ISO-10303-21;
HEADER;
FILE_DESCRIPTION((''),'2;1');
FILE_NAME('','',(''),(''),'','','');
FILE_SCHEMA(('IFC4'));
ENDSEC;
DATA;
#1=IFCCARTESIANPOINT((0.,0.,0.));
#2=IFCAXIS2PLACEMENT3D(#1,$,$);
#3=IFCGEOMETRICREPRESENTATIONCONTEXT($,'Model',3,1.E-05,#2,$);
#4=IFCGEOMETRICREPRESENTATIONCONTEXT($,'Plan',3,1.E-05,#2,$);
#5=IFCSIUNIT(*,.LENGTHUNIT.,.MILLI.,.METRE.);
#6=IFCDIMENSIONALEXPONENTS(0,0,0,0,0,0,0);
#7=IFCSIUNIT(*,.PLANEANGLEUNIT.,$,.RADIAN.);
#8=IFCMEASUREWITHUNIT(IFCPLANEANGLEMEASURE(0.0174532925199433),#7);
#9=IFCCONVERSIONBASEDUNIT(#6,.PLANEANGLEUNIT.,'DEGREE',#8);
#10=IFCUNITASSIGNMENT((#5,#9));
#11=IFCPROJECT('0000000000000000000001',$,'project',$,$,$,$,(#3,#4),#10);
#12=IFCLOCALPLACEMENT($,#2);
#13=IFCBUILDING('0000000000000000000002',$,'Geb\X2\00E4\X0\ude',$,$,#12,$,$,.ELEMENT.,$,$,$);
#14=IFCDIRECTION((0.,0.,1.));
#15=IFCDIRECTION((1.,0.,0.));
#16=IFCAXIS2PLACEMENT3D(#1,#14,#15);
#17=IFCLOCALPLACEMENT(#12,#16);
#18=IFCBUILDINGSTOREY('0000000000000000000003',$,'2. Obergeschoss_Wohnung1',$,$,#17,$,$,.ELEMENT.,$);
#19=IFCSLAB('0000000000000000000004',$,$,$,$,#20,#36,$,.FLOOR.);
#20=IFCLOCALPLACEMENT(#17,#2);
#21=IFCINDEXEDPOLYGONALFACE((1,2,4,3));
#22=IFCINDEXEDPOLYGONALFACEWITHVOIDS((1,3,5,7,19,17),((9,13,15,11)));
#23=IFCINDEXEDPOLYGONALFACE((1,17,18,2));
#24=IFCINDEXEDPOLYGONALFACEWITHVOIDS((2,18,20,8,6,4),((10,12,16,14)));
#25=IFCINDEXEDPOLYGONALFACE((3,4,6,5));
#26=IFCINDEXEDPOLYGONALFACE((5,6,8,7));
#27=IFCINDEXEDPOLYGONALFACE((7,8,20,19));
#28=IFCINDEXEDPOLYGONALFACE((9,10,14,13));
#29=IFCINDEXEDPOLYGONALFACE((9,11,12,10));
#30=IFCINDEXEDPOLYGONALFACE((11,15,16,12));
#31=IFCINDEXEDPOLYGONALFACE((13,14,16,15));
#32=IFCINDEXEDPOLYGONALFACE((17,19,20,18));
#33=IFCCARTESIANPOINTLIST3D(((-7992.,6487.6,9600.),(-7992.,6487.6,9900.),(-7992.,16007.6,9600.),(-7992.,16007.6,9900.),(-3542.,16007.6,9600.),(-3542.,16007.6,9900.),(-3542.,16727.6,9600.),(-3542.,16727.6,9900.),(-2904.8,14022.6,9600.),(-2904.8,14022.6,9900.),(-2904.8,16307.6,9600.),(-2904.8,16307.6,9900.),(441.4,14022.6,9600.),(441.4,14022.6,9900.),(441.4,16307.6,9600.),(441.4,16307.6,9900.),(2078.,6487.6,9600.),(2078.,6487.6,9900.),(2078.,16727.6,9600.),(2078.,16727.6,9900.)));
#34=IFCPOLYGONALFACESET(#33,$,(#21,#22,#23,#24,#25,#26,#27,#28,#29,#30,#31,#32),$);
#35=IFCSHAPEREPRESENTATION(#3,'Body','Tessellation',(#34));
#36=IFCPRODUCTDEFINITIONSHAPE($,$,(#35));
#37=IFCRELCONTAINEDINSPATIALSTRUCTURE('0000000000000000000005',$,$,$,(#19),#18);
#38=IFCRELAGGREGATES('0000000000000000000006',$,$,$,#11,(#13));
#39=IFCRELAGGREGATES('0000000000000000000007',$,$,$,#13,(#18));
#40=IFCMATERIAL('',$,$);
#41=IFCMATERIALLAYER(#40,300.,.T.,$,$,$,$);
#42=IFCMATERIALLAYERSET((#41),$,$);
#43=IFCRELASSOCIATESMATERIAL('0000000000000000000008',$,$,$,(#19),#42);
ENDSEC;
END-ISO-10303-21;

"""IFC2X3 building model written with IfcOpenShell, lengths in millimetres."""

from ifc_helpers import new_model, entity, si_unit, converted_unit, frame, frame_2d, origin, origin_with_axes, place, context, project, spatial, polyline, rectangle, outline, extrude, material, layer, layer_set, layer_usage, element, save


model = new_model("IFC2X3")

# Units and contexts
model_context = context("Model", 3, precision=1e-05, world=origin())
plan_context = context("Plan", 3, precision=1e-05, world=origin())
ifc_project = project(units=[si_unit("LENGTHUNIT", "METRE", prefix="MILLI"), converted_unit("PLANEANGLEUNIT", "DEGREE", entity("IfcPlaneAngleMeasure", 0.0174532925199433), si_unit("PLANEANGLEUNIT", "RADIAN"), dimensions=[0, 0, 0, 0, 0, 0, 0])], contexts=[model_context, plan_context])

# Building, storey
building_placement = place(None, origin())
building = spatial("IfcBuilding", under=ifc_project, at=building_placement, Name="Gebäude", CompositionType="ELEMENT")
storey_placement = place(building_placement, origin_with_axes())
storey = spatial("IfcBuildingStorey", under=building, at=storey_placement, Name="2. Obergeschoss_Wohnung1", CompositionType="ELEMENT")

# Slab, opening
ifc_material = material(Name="")
ifc_layer = layer(ifc_material, 300.0, ventilated=True)
ifc_layer_set = layer_set([ifc_layer])
ifc_layer_usage = layer_usage(ifc_layer_set, "AXIS3", "POSITIVE", 0.0)
slab_placement = place(storey_placement, frame((-7992.0, 6487.6, 9600.0), z_axis=(0.0, 0.0, 1.0), x_axis=(1.0, 0.0, 0.0)))
slab = element("IfcSlab", 1, at=slab_placement, inside=storey, material=ifc_layer_usage, PredefinedType="FLOOR", context=model_context, shape_type="SweptSolid", body=[
    extrude(outline(polyline([(0.0, 9520.0), (0.0, 0.0), (10070.0, 0.0), (10070.0, 10240.0), (4450.0, 10240.0), (4450.0, 9520.0), (0.0, 9520.0)])), origin_with_axes(), (0.0, 0.0, 1.0), 300.0),
])
opening_placement = place(slab_placement, frame((5087.3, 7535.0, 0.0), z_axis=(0.0, 0.0, 1.0), x_axis=(1.0, 0.0, 0.0)))
element("IfcOpeningElement", 2, at=opening_placement, cuts=slab, ObjectType="Opening", context=model_context, shape_type="SweptSolid", body=[
    extrude(rectangle(XDim=3346.2, YDim=2285.0, at=frame_2d((1673.1, 1142.5), x_axis=(1.0, 0.0))), origin_with_axes(), (0.0, 0.0, 1.0), 300.0),
])

save(model, "model.ifc")
